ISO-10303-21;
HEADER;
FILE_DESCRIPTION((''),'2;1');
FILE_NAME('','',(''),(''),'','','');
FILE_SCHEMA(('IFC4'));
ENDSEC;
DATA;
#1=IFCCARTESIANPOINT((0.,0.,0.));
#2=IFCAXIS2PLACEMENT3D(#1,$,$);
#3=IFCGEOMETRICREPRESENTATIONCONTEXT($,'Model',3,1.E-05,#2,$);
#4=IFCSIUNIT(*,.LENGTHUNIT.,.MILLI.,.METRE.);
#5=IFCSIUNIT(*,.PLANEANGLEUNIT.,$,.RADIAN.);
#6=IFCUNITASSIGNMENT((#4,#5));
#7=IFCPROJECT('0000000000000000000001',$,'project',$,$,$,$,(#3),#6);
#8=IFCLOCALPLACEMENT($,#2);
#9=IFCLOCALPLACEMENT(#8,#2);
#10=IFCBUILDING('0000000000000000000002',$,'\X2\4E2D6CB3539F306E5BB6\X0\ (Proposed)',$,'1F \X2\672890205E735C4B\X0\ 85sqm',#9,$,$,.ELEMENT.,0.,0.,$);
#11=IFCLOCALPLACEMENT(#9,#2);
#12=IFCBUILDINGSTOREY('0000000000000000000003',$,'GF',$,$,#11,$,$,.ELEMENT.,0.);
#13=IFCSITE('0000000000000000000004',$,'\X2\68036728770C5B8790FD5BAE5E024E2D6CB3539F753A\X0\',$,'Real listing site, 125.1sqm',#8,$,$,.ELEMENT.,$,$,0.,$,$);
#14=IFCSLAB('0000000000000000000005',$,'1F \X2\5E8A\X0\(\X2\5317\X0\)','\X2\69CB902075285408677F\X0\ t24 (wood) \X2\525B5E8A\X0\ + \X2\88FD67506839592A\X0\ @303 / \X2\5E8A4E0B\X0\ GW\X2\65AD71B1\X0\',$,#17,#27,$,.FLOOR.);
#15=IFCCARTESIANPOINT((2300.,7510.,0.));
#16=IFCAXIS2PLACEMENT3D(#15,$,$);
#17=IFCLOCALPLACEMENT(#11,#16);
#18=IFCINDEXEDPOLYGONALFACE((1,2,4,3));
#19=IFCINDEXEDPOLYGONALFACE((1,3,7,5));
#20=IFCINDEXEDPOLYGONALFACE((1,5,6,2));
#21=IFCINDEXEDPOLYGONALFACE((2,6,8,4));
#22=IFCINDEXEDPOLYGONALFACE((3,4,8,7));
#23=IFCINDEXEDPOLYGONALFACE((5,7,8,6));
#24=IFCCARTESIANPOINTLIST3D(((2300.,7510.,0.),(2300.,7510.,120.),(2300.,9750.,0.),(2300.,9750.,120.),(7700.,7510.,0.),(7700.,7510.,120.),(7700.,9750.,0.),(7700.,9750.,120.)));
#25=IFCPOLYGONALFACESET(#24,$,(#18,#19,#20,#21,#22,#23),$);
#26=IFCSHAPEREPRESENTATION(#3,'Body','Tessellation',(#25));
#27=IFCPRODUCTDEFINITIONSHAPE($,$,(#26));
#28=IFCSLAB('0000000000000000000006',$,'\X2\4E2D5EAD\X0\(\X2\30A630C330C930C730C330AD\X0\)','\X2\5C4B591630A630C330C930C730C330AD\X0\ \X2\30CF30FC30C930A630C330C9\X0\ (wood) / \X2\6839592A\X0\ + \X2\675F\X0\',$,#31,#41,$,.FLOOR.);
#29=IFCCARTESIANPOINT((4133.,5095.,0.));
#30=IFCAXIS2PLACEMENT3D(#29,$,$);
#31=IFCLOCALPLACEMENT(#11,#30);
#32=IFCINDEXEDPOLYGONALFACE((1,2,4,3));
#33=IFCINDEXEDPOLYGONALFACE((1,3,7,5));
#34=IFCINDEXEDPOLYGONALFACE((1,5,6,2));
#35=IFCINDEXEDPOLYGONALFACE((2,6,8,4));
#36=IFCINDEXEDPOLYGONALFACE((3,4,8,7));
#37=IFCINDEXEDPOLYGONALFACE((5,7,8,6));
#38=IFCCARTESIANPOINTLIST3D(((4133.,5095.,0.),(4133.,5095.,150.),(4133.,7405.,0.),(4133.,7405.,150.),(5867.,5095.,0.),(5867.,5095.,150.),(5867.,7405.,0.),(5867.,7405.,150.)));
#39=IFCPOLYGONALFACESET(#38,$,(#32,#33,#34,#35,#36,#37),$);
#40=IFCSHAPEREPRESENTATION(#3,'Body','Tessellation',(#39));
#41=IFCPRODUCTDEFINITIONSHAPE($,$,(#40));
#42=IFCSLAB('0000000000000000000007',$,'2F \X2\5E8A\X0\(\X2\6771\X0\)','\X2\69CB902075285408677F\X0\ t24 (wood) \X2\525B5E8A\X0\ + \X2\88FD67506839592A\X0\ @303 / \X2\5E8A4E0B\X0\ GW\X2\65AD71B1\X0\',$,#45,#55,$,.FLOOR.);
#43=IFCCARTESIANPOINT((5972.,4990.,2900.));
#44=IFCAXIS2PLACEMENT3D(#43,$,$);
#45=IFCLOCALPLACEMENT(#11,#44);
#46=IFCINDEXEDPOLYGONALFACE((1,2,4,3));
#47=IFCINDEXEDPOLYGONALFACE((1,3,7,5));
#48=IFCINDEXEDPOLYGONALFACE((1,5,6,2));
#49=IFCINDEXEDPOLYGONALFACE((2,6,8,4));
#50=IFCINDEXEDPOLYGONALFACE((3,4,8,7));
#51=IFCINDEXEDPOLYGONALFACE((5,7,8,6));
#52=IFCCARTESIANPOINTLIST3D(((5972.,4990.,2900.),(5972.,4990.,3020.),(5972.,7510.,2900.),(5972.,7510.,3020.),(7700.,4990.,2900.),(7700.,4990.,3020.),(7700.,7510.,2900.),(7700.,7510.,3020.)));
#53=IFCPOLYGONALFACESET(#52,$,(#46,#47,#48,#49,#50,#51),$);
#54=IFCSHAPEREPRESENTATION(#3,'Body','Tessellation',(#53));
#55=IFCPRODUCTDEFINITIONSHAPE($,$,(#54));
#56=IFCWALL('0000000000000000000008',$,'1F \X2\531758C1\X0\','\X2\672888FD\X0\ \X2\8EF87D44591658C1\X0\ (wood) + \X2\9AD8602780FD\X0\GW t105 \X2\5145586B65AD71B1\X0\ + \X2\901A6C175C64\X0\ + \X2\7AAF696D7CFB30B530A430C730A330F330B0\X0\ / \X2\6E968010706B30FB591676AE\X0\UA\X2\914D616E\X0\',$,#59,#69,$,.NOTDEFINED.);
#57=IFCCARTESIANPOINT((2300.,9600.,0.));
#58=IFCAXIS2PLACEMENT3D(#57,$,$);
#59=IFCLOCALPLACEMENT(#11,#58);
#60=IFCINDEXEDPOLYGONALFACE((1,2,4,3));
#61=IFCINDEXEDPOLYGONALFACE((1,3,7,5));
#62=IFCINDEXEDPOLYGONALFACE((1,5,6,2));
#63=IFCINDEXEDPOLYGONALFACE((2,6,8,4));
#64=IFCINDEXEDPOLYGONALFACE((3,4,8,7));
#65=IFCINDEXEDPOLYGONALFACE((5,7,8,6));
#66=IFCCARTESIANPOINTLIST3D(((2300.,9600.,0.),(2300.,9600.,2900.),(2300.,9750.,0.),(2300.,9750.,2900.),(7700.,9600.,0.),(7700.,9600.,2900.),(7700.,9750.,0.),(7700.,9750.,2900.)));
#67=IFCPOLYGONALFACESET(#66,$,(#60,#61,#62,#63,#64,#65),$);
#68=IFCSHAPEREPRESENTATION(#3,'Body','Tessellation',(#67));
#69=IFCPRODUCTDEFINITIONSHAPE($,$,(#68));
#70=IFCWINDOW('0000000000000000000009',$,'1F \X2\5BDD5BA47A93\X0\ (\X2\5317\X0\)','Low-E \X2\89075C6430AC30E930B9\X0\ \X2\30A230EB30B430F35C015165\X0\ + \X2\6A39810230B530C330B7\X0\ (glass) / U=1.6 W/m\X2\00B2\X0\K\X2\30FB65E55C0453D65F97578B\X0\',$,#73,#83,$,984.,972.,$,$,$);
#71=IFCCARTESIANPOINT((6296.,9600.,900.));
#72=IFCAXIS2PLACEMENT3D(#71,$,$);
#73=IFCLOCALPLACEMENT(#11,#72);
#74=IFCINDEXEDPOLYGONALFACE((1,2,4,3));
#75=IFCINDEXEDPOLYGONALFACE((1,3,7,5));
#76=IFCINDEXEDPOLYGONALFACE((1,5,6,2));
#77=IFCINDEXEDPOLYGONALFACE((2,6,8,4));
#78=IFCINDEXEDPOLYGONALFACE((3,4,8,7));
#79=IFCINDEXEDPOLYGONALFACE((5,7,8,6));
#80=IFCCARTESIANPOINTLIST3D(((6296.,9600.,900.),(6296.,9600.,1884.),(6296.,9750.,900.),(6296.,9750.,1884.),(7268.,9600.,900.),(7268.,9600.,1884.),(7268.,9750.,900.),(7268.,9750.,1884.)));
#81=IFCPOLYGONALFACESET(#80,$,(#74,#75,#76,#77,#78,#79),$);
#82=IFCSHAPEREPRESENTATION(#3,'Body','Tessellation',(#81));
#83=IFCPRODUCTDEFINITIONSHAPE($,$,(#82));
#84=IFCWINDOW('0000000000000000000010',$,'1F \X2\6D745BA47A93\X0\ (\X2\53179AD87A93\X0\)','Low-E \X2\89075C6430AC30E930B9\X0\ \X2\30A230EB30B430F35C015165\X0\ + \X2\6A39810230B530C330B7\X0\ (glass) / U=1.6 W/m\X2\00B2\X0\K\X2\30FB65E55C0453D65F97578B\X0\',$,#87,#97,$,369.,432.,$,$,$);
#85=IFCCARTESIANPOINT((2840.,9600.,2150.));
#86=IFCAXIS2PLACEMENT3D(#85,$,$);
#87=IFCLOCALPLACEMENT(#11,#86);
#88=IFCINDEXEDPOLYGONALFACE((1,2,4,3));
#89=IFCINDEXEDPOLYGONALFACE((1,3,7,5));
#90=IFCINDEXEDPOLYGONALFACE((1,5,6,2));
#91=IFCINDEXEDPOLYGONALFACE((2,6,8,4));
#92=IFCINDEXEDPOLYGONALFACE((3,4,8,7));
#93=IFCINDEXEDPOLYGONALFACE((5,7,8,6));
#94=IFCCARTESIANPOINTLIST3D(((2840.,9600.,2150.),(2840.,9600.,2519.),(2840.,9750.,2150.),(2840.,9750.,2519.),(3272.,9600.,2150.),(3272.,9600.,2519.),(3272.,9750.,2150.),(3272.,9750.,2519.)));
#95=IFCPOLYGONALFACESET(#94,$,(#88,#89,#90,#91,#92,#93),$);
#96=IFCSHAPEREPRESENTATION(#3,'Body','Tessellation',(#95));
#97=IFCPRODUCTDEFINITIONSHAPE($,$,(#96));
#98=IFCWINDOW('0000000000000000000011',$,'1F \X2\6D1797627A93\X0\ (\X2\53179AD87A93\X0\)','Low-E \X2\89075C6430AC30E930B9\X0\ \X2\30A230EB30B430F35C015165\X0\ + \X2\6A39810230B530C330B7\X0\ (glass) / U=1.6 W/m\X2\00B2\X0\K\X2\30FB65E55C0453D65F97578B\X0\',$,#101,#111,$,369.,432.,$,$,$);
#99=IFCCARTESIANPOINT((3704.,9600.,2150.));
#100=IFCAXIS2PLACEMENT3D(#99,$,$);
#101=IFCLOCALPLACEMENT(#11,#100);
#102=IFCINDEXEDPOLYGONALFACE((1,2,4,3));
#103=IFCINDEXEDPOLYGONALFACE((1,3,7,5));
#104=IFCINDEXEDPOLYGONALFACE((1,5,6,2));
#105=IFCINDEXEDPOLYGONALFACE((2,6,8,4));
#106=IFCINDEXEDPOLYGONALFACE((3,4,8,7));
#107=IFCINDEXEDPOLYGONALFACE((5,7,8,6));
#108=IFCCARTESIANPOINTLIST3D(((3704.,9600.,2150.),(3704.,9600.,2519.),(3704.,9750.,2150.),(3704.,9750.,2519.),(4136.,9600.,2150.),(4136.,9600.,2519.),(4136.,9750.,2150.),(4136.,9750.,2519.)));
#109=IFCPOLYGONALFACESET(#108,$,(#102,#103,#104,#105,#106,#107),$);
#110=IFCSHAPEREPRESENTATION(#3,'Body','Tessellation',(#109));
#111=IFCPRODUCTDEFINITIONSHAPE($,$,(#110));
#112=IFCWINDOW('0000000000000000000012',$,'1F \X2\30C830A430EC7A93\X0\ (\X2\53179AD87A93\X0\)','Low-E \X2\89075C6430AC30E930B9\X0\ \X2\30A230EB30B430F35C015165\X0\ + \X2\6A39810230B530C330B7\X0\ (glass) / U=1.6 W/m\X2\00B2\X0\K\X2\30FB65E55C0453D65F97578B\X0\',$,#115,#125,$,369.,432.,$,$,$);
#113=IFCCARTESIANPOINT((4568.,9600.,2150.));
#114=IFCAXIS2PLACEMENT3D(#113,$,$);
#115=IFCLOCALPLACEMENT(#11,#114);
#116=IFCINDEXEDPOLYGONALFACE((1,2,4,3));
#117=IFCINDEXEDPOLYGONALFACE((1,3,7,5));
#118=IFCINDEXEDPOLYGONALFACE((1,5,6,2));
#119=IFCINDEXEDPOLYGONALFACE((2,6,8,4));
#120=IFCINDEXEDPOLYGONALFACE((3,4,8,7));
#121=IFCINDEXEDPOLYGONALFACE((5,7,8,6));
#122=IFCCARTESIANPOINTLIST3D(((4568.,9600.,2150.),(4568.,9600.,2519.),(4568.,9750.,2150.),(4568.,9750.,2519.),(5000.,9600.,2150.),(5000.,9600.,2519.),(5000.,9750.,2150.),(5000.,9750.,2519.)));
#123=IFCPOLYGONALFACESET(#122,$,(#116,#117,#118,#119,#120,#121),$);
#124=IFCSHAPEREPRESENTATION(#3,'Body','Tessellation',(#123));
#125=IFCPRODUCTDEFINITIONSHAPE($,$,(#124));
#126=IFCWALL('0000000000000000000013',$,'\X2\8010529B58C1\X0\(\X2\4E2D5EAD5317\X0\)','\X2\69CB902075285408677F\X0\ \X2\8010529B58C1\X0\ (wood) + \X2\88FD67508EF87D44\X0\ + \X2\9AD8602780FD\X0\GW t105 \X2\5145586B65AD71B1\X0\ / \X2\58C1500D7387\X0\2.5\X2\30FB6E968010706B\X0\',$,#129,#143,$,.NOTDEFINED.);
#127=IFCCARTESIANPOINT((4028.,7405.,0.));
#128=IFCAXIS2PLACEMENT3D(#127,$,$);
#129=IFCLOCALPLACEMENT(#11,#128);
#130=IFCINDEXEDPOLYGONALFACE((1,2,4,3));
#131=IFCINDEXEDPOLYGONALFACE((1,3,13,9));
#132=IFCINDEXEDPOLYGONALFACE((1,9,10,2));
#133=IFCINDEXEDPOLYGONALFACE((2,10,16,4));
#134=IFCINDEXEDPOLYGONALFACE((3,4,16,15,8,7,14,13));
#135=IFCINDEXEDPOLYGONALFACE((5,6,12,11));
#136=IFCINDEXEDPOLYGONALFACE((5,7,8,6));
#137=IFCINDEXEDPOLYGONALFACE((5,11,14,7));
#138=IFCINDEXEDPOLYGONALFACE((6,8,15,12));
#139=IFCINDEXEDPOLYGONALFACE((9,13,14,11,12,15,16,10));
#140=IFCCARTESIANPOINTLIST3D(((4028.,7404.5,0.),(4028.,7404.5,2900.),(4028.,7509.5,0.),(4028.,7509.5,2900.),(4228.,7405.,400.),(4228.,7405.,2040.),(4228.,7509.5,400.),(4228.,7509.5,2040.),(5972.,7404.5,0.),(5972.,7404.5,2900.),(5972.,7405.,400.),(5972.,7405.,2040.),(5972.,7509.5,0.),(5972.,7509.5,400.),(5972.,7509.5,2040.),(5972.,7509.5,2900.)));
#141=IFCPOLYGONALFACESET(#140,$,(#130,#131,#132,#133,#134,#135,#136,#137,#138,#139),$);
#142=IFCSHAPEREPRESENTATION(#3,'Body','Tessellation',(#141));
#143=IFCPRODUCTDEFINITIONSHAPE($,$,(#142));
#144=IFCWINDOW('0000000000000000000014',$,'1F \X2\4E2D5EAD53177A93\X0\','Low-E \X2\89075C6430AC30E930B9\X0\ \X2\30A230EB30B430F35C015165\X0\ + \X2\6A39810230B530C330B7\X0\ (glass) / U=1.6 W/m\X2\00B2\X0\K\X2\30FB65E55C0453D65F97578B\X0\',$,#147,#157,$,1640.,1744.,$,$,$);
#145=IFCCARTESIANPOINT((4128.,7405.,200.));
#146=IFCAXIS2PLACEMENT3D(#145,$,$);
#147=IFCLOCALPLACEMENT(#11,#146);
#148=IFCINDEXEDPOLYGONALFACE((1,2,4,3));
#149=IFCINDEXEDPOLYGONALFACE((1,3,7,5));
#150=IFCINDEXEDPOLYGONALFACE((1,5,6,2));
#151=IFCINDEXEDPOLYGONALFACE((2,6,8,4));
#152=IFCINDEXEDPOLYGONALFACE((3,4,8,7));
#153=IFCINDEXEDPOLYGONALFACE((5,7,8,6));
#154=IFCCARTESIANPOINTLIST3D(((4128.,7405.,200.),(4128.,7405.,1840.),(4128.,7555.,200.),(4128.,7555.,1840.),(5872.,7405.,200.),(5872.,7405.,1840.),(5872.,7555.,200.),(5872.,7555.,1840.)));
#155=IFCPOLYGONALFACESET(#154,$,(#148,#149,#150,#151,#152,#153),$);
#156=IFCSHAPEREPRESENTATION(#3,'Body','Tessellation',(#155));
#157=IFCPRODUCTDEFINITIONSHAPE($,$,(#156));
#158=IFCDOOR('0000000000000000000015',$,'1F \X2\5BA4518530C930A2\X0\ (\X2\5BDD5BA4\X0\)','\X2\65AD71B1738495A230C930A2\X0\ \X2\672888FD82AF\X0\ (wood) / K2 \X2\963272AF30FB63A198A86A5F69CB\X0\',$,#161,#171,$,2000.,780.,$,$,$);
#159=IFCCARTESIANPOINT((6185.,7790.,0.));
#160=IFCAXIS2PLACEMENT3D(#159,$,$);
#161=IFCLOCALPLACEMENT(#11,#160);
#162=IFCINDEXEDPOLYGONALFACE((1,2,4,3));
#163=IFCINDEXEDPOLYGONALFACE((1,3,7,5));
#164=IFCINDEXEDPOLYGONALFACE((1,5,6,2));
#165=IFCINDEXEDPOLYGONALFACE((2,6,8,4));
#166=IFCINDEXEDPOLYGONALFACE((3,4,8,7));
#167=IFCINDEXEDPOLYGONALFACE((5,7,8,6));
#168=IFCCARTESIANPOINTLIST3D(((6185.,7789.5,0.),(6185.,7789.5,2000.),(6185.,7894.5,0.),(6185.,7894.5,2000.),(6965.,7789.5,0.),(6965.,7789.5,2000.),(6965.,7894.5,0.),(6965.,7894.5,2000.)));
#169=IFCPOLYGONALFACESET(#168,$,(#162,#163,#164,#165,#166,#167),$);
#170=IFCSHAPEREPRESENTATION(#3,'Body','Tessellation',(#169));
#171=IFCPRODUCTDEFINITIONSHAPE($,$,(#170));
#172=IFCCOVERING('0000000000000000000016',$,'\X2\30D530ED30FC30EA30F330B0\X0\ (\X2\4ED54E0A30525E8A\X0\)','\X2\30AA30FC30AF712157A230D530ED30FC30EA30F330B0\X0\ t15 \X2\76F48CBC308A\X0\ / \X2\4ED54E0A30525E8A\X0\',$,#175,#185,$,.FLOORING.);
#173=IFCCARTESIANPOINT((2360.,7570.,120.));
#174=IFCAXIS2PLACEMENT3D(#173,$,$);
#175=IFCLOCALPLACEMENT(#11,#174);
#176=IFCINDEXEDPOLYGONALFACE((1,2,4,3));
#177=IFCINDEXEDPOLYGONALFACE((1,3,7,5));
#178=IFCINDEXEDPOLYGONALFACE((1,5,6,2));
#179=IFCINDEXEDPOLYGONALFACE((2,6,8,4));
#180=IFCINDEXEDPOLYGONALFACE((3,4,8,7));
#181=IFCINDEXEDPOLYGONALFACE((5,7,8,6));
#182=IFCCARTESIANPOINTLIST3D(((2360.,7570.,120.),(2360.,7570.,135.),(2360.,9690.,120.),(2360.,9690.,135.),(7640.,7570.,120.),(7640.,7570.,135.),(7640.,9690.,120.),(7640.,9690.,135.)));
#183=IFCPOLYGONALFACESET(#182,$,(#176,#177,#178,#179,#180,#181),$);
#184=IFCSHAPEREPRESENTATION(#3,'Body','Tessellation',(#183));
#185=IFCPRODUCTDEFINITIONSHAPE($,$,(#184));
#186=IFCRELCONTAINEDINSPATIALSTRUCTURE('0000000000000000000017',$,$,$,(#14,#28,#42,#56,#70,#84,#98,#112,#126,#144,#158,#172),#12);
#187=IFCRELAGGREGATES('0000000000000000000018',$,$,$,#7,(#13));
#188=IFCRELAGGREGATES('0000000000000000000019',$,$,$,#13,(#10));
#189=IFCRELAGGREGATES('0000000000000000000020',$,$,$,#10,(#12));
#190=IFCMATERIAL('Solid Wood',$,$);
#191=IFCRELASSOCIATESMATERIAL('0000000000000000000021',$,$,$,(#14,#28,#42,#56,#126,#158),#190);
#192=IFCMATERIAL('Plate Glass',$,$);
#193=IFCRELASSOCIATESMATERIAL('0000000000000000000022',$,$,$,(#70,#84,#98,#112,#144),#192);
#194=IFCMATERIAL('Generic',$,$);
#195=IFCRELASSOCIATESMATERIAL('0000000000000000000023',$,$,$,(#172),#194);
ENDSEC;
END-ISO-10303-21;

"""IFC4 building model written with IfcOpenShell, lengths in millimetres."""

from ifc_helpers import new_model, si_unit, frame, frame_2d, origin, place, context, project, spatial, rectangle, extrude, material, element, fill, save


model = new_model("IFC4")

# Units and contexts
model_context = context("Model", 3, precision=1e-05, world=origin())
ifc_project = project(units=[si_unit("LENGTHUNIT", "METRE", prefix="MILLI"), si_unit("PLANEANGLEUNIT", "RADIAN")], contexts=[model_context])

# Site, building, storey
site_placement = place(None, origin())
site = spatial("IfcSite", under=ifc_project, at=site_placement, Name="栃木県宇都宮市中河原町", ObjectType="Real listing site, 125.1sqm", CompositionType="ELEMENT", RefElevation=0.0)
building_placement = place(site_placement, origin())
building = spatial("IfcBuilding", under=site, at=building_placement, Name="中河原の家 (Proposed)", ObjectType="1F 木造平屋 85sqm", CompositionType="ELEMENT", ElevationOfRefHeight=0.0, ElevationOfTerrain=0.0)
storey_placement = place(building_placement, origin())
storey = spatial("IfcBuildingStorey", under=building, at=storey_placement, Name="GF", CompositionType="ELEMENT", Elevation=0.0)

# Slabs
ifc_material_1 = material(Name="Solid Wood")
slab_1_placement = place(storey_placement, frame((2300.0, 7510.0, 0.0)))
element("IfcSlab", 1, at=slab_1_placement, inside=storey, material=ifc_material_1, Name="1F 床(北)", Description="構造用合板 t24 (wood) 剛床 + 製材根太 @303 / 床下 GW断熱", PredefinedType="FLOOR", context=model_context, shape_type="SweptSolid", body=[
    extrude(rectangle(XDim=5400.0, YDim=2240.0, at=frame_2d((2700.0, 1120.0))), frame((2300.0, 7510.0, 0.0)), (0.0, 0.0, 1.0), 120.0),
])
slab_2_placement = place(storey_placement, frame((4133.0, 5095.0, 0.0)))
element("IfcSlab", 2, at=slab_2_placement, inside=storey, material=ifc_material_1, Name="中庭(ウッドデッキ)", Description="屋外ウッドデッキ ハードウッド (wood) / 根太 + 束", PredefinedType="FLOOR", context=model_context, shape_type="SweptSolid", body=[
    extrude(rectangle(XDim=1734.0, YDim=2310.0, at=frame_2d((867.0, 1155.0))), frame((4133.0, 5095.0, 0.0)), (0.0, 0.0, 1.0), 150.0),
])
slab_3_placement = place(storey_placement, frame((5972.0, 4990.0, 2900.0)))
element("IfcSlab", 3, at=slab_3_placement, inside=storey, material=ifc_material_1, Name="2F 床(東)", Description="構造用合板 t24 (wood) 剛床 + 製材根太 @303 / 床下 GW断熱", PredefinedType="FLOOR", context=model_context, shape_type="SweptSolid", body=[
    extrude(rectangle(XDim=1728.0, YDim=2520.0, at=frame_2d((864.0, 1260.0))), frame((5972.0, 4990.0, 2900.0)), (0.0, 0.0, 1.0), 120.0),
])

# Wall, openings, windows
wall_1_placement = place(storey_placement, frame((2300.0, 9600.0, 0.0)))
wall_1 = element("IfcWall", 4, at=wall_1_placement, inside=storey, material=ifc_material_1, Name="1F 北壁", Description="木製 軸組外壁 (wood) + 高性能GW t105 充填断熱 + 通気層 + 窯業系サイディング / 準耐火・外皮UA配慮", PredefinedType="NOTDEFINED", context=model_context, shape_type="SweptSolid", body=[
    extrude(rectangle(XDim=5400.0, YDim=150.0, at=frame_2d((2700.0, 75.0))), frame((2300.0, 9600.0, 0.0)), (0.0, 0.0, 1.0), 2900.0),
])
opening_1_placement = place(storey_placement, frame((6296.0, 9600.0, 900.0)))
opening_1 = element("IfcOpeningElement", 5, at=opening_1_placement, cuts=wall_1, PredefinedType="NOTDEFINED", context=model_context, shape_type="SweptSolid", body=[
    extrude(rectangle(XDim=972.0, YDim=150.0, at=frame_2d((486.0, 75.0))), frame((6296.0, 9600.0, 900.0)), (0.0, 0.0, 1.0), 984.0),
])
opening_2_placement = place(storey_placement, frame((2840.0, 9600.0, 2150.0)))
opening_2 = element("IfcOpeningElement", 6, at=opening_2_placement, cuts=wall_1, PredefinedType="NOTDEFINED", context=model_context, shape_type="SweptSolid", body=[
    extrude(rectangle(XDim=432.0, YDim=150.0, at=frame_2d((216.0, 75.0))), frame((2840.0, 9600.0, 2150.0)), (0.0, 0.0, 1.0), 369.0),
])
opening_3_placement = place(storey_placement, frame((3704.0, 9600.0, 2150.0)))
opening_3 = element("IfcOpeningElement", 7, at=opening_3_placement, cuts=wall_1, PredefinedType="NOTDEFINED", context=model_context, shape_type="SweptSolid", body=[
    extrude(rectangle(XDim=432.0, YDim=150.0, at=frame_2d((216.0, 75.0))), frame((3704.0, 9600.0, 2150.0)), (0.0, 0.0, 1.0), 369.0),
])
opening_4_placement = place(storey_placement, frame((4568.0, 9600.0, 2150.0)))
opening_4 = element("IfcOpeningElement", 8, at=opening_4_placement, cuts=wall_1, PredefinedType="NOTDEFINED", context=model_context, shape_type="SweptSolid", body=[
    extrude(rectangle(XDim=432.0, YDim=150.0, at=frame_2d((216.0, 75.0))), frame((4568.0, 9600.0, 2150.0)), (0.0, 0.0, 1.0), 369.0),
])
ifc_material_2 = material(Name="Plate Glass")
window_1_placement = place(storey_placement, frame((6296.0, 9600.0, 900.0)))
window_1 = element("IfcWindow", 9, at=window_1_placement, inside=storey, material=ifc_material_2, Name="1F 寝室窓 (北)", Description="Low-E 複層ガラス アルゴン封入 + 樹脂サッシ (glass) / U=1.6 W/m²K・日射取得型", OverallHeight=984.0, OverallWidth=972.0, context=model_context, shape_type="SweptSolid", body=[
    extrude(rectangle(XDim=972.0, YDim=150.0, at=frame_2d((486.0, 75.0))), frame((6296.0, 9600.0, 900.0)), (0.0, 0.0, 1.0), 984.0),
])
fill(opening_1, window_1)
window_2_placement = place(storey_placement, frame((2840.0, 9600.0, 2150.0)))
window_2 = element("IfcWindow", 10, at=window_2_placement, inside=storey, material=ifc_material_2, Name="1F 浴室窓 (北高窓)", Description="Low-E 複層ガラス アルゴン封入 + 樹脂サッシ (glass) / U=1.6 W/m²K・日射取得型", OverallHeight=369.0, OverallWidth=432.0, context=model_context, shape_type="SweptSolid", body=[
    extrude(rectangle(XDim=432.0, YDim=150.0, at=frame_2d((216.0, 75.0))), frame((2840.0, 9600.0, 2150.0)), (0.0, 0.0, 1.0), 369.0),
])
fill(opening_2, window_2)
window_3_placement = place(storey_placement, frame((3704.0, 9600.0, 2150.0)))
window_3 = element("IfcWindow", 11, at=window_3_placement, inside=storey, material=ifc_material_2, Name="1F 洗面窓 (北高窓)", Description="Low-E 複層ガラス アルゴン封入 + 樹脂サッシ (glass) / U=1.6 W/m²K・日射取得型", OverallHeight=369.0, OverallWidth=432.0, context=model_context, shape_type="SweptSolid", body=[
    extrude(rectangle(XDim=432.0, YDim=150.0, at=frame_2d((216.0, 75.0))), frame((3704.0, 9600.0, 2150.0)), (0.0, 0.0, 1.0), 369.0),
])
fill(opening_3, window_3)
window_4_placement = place(storey_placement, frame((4568.0, 9600.0, 2150.0)))
window_4 = element("IfcWindow", 12, at=window_4_placement, inside=storey, material=ifc_material_2, Name="1F トイレ窓 (北高窓)", Description="Low-E 複層ガラス アルゴン封入 + 樹脂サッシ (glass) / U=1.6 W/m²K・日射取得型", OverallHeight=369.0, OverallWidth=432.0, context=model_context, shape_type="SweptSolid", body=[
    extrude(rectangle(XDim=432.0, YDim=150.0, at=frame_2d((216.0, 75.0))), frame((4568.0, 9600.0, 2150.0)), (0.0, 0.0, 1.0), 369.0),
])
fill(opening_4, window_4)

# Wall, opening, window
wall_2_placement = place(storey_placement, frame((4028.0, 7405.0, 0.0)))
wall_2 = element("IfcWall", 13, at=wall_2_placement, inside=storey, material=ifc_material_1, Name="耐力壁(中庭北)", Description="構造用合板 耐力壁 (wood) + 製材軸組 + 高性能GW t105 充填断熱 / 壁倍率2.5・準耐火", PredefinedType="NOTDEFINED", context=model_context, shape_type="SweptSolid", body=[
    extrude(rectangle(XDim=1944.0, YDim=105.0, at=frame_2d((972.0, 52.0))), frame((4028.0, 7405.0, 0.0)), (0.0, 0.0, 1.0), 2900.0),
])
opening_5_placement = place(storey_placement, frame((4128.0, 7405.0, 200.0)))
opening_5 = element("IfcOpeningElement", 14, at=opening_5_placement, cuts=wall_2, PredefinedType="NOTDEFINED", context=model_context, shape_type="SweptSolid", body=[
    extrude(rectangle(XDim=1744.0, YDim=150.0, at=frame_2d((872.0, 75.0))), frame((4128.0, 7405.0, 200.0)), (0.0, 0.0, 1.0), 1640.0),
])
window_5_placement = place(storey_placement, frame((4128.0, 7405.0, 200.0)))
window_5 = element("IfcWindow", 15, at=window_5_placement, inside=storey, material=ifc_material_2, Name="1F 中庭北窓", Description="Low-E 複層ガラス アルゴン封入 + 樹脂サッシ (glass) / U=1.6 W/m²K・日射取得型", OverallHeight=1640.0, OverallWidth=1744.0, context=model_context, shape_type="SweptSolid", body=[
    extrude(rectangle(XDim=1744.0, YDim=150.0, at=frame_2d((872.0, 75.0))), frame((4128.0, 7405.0, 200.0)), (0.0, 0.0, 1.0), 1640.0),
])
fill(opening_5, window_5)

# Door
door_1_placement = place(storey_placement, frame((6185.0, 7790.0, 0.0)))
element("IfcDoor", 16, at=door_1_placement, inside=storey, material=ifc_material_1, Name="1F 室内ドア (寝室)", Description="断熱玄関ドア 木製芯 (wood) / K2 防犯・採風機構", OverallHeight=2000.0, OverallWidth=780.0, context=model_context, shape_type="SweptSolid", body=[
    extrude(rectangle(XDim=780.0, YDim=105.0, at=frame_2d((390.0, 52.0))), frame((6185.0, 7790.0, 0.0)), (0.0, 0.0, 1.0), 2000.0),
])

# Covering
ifc_material_3 = material(Name="Generic")
covering_1_placement = place(storey_placement, frame((2360.0, 7570.0, 120.0)))
element("IfcCovering", 17, at=covering_1_placement, inside=storey, material=ifc_material_3, Name="フローリング (仕上げ床)", Description="オーク無垢フローリング t15 直貼り / 仕上げ床", PredefinedType="FLOORING", context=model_context, shape_type="SweptSolid", body=[
    extrude(rectangle(XDim=5280.0, YDim=2120.0, at=frame_2d((2640.0, 1060.0))), frame((2360.0, 7570.0, 120.0)), (0.0, 0.0, 1.0), 15.0),
])

save(model, "model.ifc")
